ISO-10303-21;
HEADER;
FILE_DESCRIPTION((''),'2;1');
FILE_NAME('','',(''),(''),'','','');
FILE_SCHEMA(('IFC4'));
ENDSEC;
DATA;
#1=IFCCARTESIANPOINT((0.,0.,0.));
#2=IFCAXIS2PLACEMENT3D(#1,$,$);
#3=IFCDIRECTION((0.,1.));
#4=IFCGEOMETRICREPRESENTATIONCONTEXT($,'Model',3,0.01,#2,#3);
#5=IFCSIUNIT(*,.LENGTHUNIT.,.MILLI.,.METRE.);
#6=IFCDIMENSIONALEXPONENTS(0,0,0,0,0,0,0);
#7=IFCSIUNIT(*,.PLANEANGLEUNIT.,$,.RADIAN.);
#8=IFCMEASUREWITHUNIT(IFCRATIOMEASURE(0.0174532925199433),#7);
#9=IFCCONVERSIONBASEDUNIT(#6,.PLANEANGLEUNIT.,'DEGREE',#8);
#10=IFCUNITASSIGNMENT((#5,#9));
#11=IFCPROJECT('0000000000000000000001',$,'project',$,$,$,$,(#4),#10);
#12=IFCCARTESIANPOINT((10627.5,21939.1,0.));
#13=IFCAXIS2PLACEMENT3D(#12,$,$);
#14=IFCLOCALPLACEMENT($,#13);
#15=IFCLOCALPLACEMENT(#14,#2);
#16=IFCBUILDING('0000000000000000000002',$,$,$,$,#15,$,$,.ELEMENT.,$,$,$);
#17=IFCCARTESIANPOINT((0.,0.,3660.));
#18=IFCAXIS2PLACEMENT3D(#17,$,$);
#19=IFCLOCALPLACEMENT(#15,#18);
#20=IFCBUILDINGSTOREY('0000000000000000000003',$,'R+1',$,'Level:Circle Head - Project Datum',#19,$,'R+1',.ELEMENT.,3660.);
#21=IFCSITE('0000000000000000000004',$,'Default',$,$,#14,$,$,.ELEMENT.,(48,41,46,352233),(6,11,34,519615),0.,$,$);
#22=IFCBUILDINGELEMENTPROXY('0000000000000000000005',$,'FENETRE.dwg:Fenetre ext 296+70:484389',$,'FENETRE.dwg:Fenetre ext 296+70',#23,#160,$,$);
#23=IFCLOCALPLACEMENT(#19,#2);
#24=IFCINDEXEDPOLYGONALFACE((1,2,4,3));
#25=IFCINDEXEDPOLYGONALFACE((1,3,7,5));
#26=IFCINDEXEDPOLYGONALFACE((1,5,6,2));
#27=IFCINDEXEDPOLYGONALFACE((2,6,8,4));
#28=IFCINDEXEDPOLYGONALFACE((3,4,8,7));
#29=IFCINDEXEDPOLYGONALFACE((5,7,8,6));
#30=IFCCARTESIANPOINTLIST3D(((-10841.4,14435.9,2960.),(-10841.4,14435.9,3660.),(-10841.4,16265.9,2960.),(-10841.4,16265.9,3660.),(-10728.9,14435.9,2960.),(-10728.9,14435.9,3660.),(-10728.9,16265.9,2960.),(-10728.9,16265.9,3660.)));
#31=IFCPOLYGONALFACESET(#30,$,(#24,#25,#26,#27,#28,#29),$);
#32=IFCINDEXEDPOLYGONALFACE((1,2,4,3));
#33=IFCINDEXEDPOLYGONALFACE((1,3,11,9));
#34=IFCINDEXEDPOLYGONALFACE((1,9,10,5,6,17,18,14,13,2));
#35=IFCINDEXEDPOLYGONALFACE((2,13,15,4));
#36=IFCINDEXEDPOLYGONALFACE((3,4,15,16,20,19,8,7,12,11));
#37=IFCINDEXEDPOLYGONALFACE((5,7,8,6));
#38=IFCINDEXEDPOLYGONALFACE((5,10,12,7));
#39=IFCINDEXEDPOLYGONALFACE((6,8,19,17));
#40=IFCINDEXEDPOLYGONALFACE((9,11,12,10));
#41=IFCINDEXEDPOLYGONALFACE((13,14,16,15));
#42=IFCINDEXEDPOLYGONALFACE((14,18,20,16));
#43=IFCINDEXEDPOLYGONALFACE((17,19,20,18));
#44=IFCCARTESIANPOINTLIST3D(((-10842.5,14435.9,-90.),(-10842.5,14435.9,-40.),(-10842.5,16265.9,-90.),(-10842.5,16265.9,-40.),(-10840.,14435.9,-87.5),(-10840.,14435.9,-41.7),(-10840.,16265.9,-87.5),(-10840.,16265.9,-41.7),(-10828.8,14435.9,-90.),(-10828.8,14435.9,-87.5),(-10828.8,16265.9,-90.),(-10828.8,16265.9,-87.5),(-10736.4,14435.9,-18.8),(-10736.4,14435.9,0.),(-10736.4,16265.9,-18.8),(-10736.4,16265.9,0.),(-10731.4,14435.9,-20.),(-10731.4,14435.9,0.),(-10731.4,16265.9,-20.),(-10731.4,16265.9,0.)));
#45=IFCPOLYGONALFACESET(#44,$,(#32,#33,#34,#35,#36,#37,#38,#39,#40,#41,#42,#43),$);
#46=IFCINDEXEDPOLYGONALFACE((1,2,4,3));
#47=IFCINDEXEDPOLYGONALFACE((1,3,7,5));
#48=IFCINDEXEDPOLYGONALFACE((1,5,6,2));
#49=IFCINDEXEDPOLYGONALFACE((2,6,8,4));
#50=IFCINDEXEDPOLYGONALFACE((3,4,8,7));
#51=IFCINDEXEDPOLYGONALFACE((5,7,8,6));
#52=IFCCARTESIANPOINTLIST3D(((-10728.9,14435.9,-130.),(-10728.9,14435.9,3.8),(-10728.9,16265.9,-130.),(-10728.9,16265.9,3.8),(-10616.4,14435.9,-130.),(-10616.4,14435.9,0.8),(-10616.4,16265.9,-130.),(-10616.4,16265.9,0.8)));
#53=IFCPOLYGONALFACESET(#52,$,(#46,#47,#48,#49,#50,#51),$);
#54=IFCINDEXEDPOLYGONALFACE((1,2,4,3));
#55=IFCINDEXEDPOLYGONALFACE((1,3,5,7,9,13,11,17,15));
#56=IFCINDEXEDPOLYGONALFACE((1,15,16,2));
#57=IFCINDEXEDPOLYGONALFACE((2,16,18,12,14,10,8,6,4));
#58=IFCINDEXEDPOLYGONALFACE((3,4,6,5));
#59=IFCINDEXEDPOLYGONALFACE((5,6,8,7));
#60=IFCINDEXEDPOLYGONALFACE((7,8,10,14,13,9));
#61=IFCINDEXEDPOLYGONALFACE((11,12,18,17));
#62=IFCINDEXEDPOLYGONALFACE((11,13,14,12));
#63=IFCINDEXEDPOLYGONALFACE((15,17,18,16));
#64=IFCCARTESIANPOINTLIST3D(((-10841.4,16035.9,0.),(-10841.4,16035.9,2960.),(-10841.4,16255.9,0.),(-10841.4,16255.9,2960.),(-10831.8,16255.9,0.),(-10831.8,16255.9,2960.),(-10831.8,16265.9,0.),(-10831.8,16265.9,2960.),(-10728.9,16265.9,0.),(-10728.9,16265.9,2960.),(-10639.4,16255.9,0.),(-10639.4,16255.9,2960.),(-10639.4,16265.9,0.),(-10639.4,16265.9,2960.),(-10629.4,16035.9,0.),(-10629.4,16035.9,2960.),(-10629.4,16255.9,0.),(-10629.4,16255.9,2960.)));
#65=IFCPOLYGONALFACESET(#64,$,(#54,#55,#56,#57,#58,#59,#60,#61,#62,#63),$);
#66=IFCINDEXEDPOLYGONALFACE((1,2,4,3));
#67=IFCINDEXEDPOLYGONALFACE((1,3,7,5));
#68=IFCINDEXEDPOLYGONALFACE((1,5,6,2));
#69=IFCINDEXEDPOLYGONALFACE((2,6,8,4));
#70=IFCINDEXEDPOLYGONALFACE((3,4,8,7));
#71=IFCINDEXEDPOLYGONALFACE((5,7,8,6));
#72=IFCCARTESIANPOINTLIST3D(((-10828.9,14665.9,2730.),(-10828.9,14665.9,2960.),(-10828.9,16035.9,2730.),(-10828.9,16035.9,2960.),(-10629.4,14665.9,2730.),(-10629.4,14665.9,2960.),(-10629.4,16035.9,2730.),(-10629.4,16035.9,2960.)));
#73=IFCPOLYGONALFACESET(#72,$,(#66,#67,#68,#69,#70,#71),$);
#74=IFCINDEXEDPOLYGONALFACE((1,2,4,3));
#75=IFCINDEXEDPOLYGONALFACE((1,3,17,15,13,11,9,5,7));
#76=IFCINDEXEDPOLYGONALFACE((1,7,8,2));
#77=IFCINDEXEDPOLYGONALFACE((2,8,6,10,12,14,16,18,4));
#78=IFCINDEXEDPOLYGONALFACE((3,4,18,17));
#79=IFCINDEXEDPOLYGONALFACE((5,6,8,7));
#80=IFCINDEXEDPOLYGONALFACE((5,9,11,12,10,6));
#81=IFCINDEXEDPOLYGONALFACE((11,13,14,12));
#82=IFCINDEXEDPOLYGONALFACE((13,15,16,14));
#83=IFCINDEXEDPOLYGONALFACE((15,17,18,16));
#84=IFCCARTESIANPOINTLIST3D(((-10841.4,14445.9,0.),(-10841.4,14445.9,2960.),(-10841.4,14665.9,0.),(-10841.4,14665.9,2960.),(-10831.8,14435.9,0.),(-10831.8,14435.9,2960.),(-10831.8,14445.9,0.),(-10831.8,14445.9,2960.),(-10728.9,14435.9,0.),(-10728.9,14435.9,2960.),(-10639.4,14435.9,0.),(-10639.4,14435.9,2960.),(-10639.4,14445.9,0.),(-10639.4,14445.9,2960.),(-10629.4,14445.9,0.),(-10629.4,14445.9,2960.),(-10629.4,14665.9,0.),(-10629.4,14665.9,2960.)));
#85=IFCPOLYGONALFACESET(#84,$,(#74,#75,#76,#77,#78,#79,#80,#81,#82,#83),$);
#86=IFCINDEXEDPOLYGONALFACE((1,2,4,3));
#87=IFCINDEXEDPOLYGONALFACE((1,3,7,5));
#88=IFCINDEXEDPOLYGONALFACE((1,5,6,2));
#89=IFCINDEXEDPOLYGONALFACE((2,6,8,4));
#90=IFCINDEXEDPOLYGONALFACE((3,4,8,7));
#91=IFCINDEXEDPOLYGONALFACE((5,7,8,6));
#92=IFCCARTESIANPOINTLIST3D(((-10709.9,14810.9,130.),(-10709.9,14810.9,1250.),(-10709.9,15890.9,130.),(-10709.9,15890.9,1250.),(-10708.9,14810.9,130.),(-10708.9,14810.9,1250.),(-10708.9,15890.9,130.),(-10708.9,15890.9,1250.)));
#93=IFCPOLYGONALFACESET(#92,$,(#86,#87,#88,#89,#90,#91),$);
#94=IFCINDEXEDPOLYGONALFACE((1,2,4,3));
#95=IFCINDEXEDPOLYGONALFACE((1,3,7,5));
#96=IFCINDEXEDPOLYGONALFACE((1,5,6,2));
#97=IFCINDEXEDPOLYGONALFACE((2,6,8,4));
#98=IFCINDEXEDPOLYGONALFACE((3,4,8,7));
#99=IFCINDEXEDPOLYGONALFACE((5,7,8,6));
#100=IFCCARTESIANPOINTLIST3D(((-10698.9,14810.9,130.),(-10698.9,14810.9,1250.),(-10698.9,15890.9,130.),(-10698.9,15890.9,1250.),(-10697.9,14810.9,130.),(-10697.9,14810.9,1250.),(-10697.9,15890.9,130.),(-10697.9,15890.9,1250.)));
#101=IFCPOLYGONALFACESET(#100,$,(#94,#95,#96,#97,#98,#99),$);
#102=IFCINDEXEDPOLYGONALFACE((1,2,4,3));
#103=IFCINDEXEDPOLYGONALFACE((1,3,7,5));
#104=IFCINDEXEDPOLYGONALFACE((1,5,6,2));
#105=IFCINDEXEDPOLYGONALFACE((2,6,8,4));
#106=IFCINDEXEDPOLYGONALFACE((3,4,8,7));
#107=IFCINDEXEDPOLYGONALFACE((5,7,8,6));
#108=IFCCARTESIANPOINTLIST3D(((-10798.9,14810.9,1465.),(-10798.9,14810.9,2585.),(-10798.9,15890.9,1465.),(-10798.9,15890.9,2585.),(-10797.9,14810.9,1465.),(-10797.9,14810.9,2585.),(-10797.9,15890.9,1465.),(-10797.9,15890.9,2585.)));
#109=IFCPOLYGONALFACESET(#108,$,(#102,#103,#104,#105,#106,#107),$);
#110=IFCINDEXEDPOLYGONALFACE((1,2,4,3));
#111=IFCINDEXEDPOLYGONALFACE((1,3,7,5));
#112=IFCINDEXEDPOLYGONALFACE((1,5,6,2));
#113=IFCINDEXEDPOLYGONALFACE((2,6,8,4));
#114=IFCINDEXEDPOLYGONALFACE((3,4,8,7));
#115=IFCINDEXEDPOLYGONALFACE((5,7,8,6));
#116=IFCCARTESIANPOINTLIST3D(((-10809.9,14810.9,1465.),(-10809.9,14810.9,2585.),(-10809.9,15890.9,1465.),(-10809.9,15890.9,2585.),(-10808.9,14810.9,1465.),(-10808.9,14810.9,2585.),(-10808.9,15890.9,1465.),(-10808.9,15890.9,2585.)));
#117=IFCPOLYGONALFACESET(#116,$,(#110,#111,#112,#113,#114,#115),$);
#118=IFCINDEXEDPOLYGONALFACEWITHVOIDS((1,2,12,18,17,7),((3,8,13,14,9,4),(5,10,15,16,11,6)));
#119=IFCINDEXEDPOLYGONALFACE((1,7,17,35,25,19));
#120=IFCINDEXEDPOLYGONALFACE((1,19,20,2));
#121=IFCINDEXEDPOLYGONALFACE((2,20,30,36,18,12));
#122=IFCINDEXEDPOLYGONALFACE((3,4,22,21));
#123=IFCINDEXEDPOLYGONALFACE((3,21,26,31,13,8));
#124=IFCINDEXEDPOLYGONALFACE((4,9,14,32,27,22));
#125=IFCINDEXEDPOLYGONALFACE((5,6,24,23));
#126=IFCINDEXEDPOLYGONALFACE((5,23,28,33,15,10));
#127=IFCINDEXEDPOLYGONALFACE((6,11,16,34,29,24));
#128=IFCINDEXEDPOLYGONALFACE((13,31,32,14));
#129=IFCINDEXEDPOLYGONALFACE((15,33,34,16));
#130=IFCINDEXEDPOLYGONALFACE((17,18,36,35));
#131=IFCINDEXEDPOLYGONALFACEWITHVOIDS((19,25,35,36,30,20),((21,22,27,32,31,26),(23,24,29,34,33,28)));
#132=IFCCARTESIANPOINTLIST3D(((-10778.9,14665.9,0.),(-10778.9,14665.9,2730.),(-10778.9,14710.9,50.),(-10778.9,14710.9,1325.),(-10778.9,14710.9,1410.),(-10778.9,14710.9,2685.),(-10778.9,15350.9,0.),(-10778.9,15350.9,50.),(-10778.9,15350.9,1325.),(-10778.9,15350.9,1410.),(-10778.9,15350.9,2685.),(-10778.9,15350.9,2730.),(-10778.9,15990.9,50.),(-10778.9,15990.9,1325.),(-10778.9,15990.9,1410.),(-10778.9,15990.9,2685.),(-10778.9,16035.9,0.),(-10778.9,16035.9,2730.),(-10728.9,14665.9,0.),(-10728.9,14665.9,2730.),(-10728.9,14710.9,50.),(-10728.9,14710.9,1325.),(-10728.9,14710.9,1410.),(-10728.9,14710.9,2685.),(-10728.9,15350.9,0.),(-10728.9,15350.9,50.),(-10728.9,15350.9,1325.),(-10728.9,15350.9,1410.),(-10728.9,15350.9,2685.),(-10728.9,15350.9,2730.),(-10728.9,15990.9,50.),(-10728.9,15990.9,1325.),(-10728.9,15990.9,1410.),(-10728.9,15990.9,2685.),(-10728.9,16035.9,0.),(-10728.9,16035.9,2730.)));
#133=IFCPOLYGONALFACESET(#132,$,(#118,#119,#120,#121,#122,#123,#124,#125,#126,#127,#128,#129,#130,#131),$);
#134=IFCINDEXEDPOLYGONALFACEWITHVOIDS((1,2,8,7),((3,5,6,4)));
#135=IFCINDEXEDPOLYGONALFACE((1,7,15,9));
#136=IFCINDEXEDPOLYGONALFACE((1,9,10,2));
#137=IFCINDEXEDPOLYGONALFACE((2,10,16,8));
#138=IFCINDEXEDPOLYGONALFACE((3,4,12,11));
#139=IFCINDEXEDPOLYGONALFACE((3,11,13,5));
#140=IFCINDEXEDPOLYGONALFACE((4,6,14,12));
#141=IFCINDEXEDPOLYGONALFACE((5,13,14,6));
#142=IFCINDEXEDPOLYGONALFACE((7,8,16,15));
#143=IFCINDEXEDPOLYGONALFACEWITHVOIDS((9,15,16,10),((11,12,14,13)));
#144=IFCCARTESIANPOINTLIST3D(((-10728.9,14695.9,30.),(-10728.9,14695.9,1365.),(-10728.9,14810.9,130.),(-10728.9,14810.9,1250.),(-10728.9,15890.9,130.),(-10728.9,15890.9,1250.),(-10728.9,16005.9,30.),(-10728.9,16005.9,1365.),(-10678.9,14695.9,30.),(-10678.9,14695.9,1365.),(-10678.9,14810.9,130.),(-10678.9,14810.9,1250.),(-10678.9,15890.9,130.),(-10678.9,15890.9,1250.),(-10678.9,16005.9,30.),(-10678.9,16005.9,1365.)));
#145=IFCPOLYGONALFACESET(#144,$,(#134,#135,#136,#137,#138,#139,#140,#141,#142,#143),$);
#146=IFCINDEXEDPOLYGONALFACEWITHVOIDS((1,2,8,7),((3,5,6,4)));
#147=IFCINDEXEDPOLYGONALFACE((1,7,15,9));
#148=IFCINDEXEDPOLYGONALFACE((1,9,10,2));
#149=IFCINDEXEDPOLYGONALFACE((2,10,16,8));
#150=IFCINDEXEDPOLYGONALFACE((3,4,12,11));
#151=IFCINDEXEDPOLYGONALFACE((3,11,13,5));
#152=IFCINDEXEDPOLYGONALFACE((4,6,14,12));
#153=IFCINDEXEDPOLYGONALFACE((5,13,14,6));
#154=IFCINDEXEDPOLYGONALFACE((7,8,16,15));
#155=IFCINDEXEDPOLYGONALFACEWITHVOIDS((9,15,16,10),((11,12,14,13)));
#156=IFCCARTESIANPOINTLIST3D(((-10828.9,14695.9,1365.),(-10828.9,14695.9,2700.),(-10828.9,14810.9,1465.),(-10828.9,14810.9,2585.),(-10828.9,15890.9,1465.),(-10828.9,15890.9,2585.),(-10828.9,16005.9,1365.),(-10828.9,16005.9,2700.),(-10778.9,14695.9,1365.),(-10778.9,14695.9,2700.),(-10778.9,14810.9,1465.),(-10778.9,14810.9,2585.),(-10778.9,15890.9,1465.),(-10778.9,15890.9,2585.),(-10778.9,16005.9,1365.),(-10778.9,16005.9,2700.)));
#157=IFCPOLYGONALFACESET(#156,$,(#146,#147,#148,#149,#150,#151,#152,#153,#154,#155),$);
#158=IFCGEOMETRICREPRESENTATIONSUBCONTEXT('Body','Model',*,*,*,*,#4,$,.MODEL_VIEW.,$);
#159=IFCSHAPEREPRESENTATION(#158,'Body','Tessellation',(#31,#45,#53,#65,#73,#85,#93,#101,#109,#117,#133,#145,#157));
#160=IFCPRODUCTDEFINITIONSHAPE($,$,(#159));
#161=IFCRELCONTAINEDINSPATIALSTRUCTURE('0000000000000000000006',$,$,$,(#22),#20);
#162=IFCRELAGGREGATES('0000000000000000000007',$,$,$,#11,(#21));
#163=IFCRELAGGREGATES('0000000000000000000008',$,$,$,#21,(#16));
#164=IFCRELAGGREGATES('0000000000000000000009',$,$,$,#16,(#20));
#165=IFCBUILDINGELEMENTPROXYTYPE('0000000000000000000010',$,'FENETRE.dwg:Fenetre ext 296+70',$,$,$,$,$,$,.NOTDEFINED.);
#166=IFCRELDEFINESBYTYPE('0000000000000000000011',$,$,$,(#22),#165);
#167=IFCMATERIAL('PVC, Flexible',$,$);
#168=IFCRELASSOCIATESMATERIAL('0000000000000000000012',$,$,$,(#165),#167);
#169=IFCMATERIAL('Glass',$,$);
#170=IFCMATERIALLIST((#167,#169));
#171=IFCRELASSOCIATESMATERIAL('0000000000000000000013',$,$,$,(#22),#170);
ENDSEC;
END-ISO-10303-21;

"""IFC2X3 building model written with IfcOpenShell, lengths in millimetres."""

from ifc_helpers import new_model, entity, si_unit, converted_unit, direction, frame, frame_2d, origin, origin_2d_with_axis, place, context, subcontext, project, spatial, polyline, rectangle, outline, extrude, source, transform, mapped, material, material_list, type_object, type_shapes, element, save


model = new_model("IFC2X3")

# Units and contexts
model_context = context("Model", 3, precision=0.01, world=origin(), true_north=direction((0.0, 1.0)))
body_context = subcontext(model_context, "Body", "Model", "MODEL_VIEW")
ifc_project = project(units=[si_unit("LENGTHUNIT", "METRE", prefix="MILLI"), converted_unit("PLANEANGLEUNIT", "DEGREE", entity("IfcRatioMeasure", 0.0174532925199433), si_unit("PLANEANGLEUNIT", "RADIAN"), dimensions=[0, 0, 0, 0, 0, 0, 0])], contexts=[model_context])

# Site, building, storey
site_placement = place(None, frame((10627.5, 21939.1, 0.0)))
site = spatial("IfcSite", under=ifc_project, at=site_placement, Name="Default", CompositionType="ELEMENT", RefLatitude=(48, 41, 46, 352233), RefLongitude=(6, 11, 34, 519615), RefElevation=0.0)
building_placement = place(site_placement, origin())
building = spatial("IfcBuilding", under=site, at=building_placement, CompositionType="ELEMENT")
storey_placement = place(building_placement, frame((0.0, 0.0, 3660.0)))
storey = spatial("IfcBuildingStorey", under=building, at=storey_placement, Name="R+1", ObjectType="Level:Circle Head - Project Datum", LongName="R+1", CompositionType="ELEMENT", Elevation=3660.0)

# Building element proxy
ifc_material_1 = material(Name="PVC, Flexible")
ifc_material_2 = material(Name="Glass")
ifc_material_list_1 = material_list([ifc_material_1, ifc_material_2])
building_element_proxy_type_1 = type_object("IfcBuildingElementProxyType", Name="FENETRE.dwg:Fenetre ext 296+70", PredefinedType="NOTDEFINED", material=ifc_material_1)
shared_shape_1 = source(origin(), body_context, "Body", "SweptSolid", [
    extrude(rectangle(XDim=1830.0, YDim=112.5, at=origin_2d_with_axis()), frame((-10.4, 56.3, 2960.0), z_axis=(0.0, 0.0, 1.0), x_axis=(-1.0, 0.0, 0.0)), (0.0, 0.0, 1.0), 700.0),
    extrude(outline(polyline([(-68.6, -14.4), (-72.5, -34.0), (-67.6, -35.0), (-63.9, -16.6), (44.3, -16.6), (54.1, 32.5), (40.6, 35.2), (40.1, 32.7), (51.2, 30.5), (42.2, -14.4), (-68.6, -14.4)])), frame((-925.4, 66.9, -47.5), z_axis=(-1.0, 0.0, 0.0), x_axis=(0.0, 0.980599, -0.196027)), (0.0, 0.0, -1.0), 1830.0),
    extrude(outline(polyline([(-64.7, -56.3), (66.2, -56.3), (66.2, 56.3), (-67.7, 56.3), (-64.7, -56.3)])), frame((-925.4, -56.3, -63.8), z_axis=(1.0, 0.0, 0.0), x_axis=(0.0, 0.0, -1.0)), (0.0, 0.0, 1.0), 1830.0),
    extrude(outline(polyline([(-55.6, 97.0), (-55.6, -5.9), (-55.6, -95.4), (-45.6, -95.4), (-45.6, -105.4), (174.4, -105.4), (174.4, 106.6), (-45.6, 106.6), (-45.6, 97.0), (-55.6, 97.0)])), frame((849.0, 5.9, 0.0), z_axis=(0.0, 0.0, -1.0), x_axis=(-1.0, 0.0, 0.0)), (0.0, 0.0, -1.0), 2960.0),
    extrude(rectangle(XDim=199.5, YDim=1370.0, at=origin_2d_with_axis()), frame((-10.4, 0.3, 2730.0), z_axis=(0.0, 0.0, 1.0), x_axis=(0.0, 1.0, 0.0)), (0.0, 0.0, 1.0), 230.0),
    extrude(outline(polyline([(-97.0, -55.6), (5.9, -55.6), (95.4, -55.6), (95.4, -45.6), (105.4, -45.6), (105.4, 174.4), (-106.6, 174.4), (-106.6, -45.6), (-97.0, -45.6), (-97.0, -55.6)])), frame((-869.9, 5.9, 0.0), z_axis=(0.0, 0.0, 1.0), x_axis=(0.0, -1.0, 0.0)), (0.0, 0.0, 1.0), 2960.0),
    extrude(rectangle(XDim=1.0, YDim=1080.0, at=origin_2d_with_axis()), frame((-10.4, -19.5, 130.0), z_axis=(0.0, 0.0, 1.0), x_axis=(0.0, 1.0, 0.0)), (0.0, 0.0, 1.0), 1120.0),
    extrude(rectangle(XDim=1.0, YDim=1080.0, at=frame_2d((0.0, 0.0), x_axis=(1.0, 0.0))), frame((-10.4, -30.5, 130.0), z_axis=(0.0, 0.0, 1.0), x_axis=(0.0, 1.0, 0.0)), (0.0, 0.0, 1.0), 1120.0),
    extrude(rectangle(XDim=1.0, YDim=1080.0, at=frame_2d((0.0, 0.0), x_axis=(1.0, 0.0))), frame((-10.4, 69.5, 1465.0), z_axis=(0.0, 0.0, 1.0), x_axis=(0.0, 1.0, 0.0)), (0.0, 0.0, 1.0), 1120.0),
    extrude(rectangle(XDim=1.0, YDim=1080.0, at=frame_2d((0.0, 0.0), x_axis=(1.0, 0.0))), frame((-10.4, 80.5, 1465.0), z_axis=(0.0, 0.0, 1.0), x_axis=(0.0, 1.0, 0.0)), (0.0, 0.0, 1.0), 1120.0),
    extrude(outline(polyline([(-685.0, -1365.0), (0.0, -1365.0), (685.0, -1365.0), (685.0, 1365.0), (0.0, 1365.0), (-685.0, 1365.0), (-685.0, -1365.0)]), holes=[polyline([(-640.0, -1320.0), (-640.0, -45.0), (0.0, -45.0), (640.0, -45.0), (640.0, -1320.0), (0.0, -1320.0), (-640.0, -1320.0)]), polyline([(-640.0, 40.0), (-640.0, 1315.0), (0.0, 1315.0), (640.0, 1315.0), (640.0, 40.0), (0.0, 40.0), (-640.0, 40.0)])]), frame((-10.4, 0.0, 1365.0), z_axis=(0.0, 1.0, 0.0), x_axis=(1.0, 0.0, 0.0)), (0.0, 0.0, 1.0), 50.0),
    extrude(outline(polyline([(-655.0, -667.5), (655.0, -667.5), (655.0, 667.5), (-655.0, 667.5), (-655.0, -667.5)]), holes=[polyline([(-540.0, 552.5), (540.0, 552.5), (540.0, -567.5), (-540.0, -567.5), (-540.0, 552.5)])]), frame((-10.4, -50.0, 697.5), z_axis=(0.0, 1.0, 0.0), x_axis=(-1.0, 0.0, 0.0)), (0.0, 0.0, 1.0), 50.0),
    extrude(outline(polyline([(-655.0, -667.5), (655.0, -667.5), (655.0, 667.5), (-655.0, 667.5), (-655.0, -667.5)]), holes=[polyline([(-540.0, 552.5), (540.0, 552.5), (540.0, -567.5), (-540.0, -567.5), (-540.0, 552.5)])]), frame((-10.4, 50.0, 2032.5), z_axis=(0.0, 1.0, 0.0), x_axis=(-1.0, 0.0, 0.0)), (0.0, 0.0, 1.0), 50.0),
])
type_shapes(building_element_proxy_type_1, [shared_shape_1])
proxy_1_placement = place(storey_placement, frame((-10728.9, 15361.3, 0.0), z_axis=(0.0, 0.0, 1.0), x_axis=(0.0, 1.0, 0.0)))
element("IfcBuildingElementProxy", 1, at=proxy_1_placement, inside=storey, type_object=building_element_proxy_type_1, material=ifc_material_list_1, Name="FENETRE.dwg:Fenetre ext 296+70:484389", ObjectType="FENETRE.dwg:Fenetre ext 296+70", context=body_context, shape_type="MappedRepresentation", body=[
    mapped(shared_shape_1, transform((0.0, 0.0, 0.0), scale=1.0)),
])

save(model, "model.ifc")
